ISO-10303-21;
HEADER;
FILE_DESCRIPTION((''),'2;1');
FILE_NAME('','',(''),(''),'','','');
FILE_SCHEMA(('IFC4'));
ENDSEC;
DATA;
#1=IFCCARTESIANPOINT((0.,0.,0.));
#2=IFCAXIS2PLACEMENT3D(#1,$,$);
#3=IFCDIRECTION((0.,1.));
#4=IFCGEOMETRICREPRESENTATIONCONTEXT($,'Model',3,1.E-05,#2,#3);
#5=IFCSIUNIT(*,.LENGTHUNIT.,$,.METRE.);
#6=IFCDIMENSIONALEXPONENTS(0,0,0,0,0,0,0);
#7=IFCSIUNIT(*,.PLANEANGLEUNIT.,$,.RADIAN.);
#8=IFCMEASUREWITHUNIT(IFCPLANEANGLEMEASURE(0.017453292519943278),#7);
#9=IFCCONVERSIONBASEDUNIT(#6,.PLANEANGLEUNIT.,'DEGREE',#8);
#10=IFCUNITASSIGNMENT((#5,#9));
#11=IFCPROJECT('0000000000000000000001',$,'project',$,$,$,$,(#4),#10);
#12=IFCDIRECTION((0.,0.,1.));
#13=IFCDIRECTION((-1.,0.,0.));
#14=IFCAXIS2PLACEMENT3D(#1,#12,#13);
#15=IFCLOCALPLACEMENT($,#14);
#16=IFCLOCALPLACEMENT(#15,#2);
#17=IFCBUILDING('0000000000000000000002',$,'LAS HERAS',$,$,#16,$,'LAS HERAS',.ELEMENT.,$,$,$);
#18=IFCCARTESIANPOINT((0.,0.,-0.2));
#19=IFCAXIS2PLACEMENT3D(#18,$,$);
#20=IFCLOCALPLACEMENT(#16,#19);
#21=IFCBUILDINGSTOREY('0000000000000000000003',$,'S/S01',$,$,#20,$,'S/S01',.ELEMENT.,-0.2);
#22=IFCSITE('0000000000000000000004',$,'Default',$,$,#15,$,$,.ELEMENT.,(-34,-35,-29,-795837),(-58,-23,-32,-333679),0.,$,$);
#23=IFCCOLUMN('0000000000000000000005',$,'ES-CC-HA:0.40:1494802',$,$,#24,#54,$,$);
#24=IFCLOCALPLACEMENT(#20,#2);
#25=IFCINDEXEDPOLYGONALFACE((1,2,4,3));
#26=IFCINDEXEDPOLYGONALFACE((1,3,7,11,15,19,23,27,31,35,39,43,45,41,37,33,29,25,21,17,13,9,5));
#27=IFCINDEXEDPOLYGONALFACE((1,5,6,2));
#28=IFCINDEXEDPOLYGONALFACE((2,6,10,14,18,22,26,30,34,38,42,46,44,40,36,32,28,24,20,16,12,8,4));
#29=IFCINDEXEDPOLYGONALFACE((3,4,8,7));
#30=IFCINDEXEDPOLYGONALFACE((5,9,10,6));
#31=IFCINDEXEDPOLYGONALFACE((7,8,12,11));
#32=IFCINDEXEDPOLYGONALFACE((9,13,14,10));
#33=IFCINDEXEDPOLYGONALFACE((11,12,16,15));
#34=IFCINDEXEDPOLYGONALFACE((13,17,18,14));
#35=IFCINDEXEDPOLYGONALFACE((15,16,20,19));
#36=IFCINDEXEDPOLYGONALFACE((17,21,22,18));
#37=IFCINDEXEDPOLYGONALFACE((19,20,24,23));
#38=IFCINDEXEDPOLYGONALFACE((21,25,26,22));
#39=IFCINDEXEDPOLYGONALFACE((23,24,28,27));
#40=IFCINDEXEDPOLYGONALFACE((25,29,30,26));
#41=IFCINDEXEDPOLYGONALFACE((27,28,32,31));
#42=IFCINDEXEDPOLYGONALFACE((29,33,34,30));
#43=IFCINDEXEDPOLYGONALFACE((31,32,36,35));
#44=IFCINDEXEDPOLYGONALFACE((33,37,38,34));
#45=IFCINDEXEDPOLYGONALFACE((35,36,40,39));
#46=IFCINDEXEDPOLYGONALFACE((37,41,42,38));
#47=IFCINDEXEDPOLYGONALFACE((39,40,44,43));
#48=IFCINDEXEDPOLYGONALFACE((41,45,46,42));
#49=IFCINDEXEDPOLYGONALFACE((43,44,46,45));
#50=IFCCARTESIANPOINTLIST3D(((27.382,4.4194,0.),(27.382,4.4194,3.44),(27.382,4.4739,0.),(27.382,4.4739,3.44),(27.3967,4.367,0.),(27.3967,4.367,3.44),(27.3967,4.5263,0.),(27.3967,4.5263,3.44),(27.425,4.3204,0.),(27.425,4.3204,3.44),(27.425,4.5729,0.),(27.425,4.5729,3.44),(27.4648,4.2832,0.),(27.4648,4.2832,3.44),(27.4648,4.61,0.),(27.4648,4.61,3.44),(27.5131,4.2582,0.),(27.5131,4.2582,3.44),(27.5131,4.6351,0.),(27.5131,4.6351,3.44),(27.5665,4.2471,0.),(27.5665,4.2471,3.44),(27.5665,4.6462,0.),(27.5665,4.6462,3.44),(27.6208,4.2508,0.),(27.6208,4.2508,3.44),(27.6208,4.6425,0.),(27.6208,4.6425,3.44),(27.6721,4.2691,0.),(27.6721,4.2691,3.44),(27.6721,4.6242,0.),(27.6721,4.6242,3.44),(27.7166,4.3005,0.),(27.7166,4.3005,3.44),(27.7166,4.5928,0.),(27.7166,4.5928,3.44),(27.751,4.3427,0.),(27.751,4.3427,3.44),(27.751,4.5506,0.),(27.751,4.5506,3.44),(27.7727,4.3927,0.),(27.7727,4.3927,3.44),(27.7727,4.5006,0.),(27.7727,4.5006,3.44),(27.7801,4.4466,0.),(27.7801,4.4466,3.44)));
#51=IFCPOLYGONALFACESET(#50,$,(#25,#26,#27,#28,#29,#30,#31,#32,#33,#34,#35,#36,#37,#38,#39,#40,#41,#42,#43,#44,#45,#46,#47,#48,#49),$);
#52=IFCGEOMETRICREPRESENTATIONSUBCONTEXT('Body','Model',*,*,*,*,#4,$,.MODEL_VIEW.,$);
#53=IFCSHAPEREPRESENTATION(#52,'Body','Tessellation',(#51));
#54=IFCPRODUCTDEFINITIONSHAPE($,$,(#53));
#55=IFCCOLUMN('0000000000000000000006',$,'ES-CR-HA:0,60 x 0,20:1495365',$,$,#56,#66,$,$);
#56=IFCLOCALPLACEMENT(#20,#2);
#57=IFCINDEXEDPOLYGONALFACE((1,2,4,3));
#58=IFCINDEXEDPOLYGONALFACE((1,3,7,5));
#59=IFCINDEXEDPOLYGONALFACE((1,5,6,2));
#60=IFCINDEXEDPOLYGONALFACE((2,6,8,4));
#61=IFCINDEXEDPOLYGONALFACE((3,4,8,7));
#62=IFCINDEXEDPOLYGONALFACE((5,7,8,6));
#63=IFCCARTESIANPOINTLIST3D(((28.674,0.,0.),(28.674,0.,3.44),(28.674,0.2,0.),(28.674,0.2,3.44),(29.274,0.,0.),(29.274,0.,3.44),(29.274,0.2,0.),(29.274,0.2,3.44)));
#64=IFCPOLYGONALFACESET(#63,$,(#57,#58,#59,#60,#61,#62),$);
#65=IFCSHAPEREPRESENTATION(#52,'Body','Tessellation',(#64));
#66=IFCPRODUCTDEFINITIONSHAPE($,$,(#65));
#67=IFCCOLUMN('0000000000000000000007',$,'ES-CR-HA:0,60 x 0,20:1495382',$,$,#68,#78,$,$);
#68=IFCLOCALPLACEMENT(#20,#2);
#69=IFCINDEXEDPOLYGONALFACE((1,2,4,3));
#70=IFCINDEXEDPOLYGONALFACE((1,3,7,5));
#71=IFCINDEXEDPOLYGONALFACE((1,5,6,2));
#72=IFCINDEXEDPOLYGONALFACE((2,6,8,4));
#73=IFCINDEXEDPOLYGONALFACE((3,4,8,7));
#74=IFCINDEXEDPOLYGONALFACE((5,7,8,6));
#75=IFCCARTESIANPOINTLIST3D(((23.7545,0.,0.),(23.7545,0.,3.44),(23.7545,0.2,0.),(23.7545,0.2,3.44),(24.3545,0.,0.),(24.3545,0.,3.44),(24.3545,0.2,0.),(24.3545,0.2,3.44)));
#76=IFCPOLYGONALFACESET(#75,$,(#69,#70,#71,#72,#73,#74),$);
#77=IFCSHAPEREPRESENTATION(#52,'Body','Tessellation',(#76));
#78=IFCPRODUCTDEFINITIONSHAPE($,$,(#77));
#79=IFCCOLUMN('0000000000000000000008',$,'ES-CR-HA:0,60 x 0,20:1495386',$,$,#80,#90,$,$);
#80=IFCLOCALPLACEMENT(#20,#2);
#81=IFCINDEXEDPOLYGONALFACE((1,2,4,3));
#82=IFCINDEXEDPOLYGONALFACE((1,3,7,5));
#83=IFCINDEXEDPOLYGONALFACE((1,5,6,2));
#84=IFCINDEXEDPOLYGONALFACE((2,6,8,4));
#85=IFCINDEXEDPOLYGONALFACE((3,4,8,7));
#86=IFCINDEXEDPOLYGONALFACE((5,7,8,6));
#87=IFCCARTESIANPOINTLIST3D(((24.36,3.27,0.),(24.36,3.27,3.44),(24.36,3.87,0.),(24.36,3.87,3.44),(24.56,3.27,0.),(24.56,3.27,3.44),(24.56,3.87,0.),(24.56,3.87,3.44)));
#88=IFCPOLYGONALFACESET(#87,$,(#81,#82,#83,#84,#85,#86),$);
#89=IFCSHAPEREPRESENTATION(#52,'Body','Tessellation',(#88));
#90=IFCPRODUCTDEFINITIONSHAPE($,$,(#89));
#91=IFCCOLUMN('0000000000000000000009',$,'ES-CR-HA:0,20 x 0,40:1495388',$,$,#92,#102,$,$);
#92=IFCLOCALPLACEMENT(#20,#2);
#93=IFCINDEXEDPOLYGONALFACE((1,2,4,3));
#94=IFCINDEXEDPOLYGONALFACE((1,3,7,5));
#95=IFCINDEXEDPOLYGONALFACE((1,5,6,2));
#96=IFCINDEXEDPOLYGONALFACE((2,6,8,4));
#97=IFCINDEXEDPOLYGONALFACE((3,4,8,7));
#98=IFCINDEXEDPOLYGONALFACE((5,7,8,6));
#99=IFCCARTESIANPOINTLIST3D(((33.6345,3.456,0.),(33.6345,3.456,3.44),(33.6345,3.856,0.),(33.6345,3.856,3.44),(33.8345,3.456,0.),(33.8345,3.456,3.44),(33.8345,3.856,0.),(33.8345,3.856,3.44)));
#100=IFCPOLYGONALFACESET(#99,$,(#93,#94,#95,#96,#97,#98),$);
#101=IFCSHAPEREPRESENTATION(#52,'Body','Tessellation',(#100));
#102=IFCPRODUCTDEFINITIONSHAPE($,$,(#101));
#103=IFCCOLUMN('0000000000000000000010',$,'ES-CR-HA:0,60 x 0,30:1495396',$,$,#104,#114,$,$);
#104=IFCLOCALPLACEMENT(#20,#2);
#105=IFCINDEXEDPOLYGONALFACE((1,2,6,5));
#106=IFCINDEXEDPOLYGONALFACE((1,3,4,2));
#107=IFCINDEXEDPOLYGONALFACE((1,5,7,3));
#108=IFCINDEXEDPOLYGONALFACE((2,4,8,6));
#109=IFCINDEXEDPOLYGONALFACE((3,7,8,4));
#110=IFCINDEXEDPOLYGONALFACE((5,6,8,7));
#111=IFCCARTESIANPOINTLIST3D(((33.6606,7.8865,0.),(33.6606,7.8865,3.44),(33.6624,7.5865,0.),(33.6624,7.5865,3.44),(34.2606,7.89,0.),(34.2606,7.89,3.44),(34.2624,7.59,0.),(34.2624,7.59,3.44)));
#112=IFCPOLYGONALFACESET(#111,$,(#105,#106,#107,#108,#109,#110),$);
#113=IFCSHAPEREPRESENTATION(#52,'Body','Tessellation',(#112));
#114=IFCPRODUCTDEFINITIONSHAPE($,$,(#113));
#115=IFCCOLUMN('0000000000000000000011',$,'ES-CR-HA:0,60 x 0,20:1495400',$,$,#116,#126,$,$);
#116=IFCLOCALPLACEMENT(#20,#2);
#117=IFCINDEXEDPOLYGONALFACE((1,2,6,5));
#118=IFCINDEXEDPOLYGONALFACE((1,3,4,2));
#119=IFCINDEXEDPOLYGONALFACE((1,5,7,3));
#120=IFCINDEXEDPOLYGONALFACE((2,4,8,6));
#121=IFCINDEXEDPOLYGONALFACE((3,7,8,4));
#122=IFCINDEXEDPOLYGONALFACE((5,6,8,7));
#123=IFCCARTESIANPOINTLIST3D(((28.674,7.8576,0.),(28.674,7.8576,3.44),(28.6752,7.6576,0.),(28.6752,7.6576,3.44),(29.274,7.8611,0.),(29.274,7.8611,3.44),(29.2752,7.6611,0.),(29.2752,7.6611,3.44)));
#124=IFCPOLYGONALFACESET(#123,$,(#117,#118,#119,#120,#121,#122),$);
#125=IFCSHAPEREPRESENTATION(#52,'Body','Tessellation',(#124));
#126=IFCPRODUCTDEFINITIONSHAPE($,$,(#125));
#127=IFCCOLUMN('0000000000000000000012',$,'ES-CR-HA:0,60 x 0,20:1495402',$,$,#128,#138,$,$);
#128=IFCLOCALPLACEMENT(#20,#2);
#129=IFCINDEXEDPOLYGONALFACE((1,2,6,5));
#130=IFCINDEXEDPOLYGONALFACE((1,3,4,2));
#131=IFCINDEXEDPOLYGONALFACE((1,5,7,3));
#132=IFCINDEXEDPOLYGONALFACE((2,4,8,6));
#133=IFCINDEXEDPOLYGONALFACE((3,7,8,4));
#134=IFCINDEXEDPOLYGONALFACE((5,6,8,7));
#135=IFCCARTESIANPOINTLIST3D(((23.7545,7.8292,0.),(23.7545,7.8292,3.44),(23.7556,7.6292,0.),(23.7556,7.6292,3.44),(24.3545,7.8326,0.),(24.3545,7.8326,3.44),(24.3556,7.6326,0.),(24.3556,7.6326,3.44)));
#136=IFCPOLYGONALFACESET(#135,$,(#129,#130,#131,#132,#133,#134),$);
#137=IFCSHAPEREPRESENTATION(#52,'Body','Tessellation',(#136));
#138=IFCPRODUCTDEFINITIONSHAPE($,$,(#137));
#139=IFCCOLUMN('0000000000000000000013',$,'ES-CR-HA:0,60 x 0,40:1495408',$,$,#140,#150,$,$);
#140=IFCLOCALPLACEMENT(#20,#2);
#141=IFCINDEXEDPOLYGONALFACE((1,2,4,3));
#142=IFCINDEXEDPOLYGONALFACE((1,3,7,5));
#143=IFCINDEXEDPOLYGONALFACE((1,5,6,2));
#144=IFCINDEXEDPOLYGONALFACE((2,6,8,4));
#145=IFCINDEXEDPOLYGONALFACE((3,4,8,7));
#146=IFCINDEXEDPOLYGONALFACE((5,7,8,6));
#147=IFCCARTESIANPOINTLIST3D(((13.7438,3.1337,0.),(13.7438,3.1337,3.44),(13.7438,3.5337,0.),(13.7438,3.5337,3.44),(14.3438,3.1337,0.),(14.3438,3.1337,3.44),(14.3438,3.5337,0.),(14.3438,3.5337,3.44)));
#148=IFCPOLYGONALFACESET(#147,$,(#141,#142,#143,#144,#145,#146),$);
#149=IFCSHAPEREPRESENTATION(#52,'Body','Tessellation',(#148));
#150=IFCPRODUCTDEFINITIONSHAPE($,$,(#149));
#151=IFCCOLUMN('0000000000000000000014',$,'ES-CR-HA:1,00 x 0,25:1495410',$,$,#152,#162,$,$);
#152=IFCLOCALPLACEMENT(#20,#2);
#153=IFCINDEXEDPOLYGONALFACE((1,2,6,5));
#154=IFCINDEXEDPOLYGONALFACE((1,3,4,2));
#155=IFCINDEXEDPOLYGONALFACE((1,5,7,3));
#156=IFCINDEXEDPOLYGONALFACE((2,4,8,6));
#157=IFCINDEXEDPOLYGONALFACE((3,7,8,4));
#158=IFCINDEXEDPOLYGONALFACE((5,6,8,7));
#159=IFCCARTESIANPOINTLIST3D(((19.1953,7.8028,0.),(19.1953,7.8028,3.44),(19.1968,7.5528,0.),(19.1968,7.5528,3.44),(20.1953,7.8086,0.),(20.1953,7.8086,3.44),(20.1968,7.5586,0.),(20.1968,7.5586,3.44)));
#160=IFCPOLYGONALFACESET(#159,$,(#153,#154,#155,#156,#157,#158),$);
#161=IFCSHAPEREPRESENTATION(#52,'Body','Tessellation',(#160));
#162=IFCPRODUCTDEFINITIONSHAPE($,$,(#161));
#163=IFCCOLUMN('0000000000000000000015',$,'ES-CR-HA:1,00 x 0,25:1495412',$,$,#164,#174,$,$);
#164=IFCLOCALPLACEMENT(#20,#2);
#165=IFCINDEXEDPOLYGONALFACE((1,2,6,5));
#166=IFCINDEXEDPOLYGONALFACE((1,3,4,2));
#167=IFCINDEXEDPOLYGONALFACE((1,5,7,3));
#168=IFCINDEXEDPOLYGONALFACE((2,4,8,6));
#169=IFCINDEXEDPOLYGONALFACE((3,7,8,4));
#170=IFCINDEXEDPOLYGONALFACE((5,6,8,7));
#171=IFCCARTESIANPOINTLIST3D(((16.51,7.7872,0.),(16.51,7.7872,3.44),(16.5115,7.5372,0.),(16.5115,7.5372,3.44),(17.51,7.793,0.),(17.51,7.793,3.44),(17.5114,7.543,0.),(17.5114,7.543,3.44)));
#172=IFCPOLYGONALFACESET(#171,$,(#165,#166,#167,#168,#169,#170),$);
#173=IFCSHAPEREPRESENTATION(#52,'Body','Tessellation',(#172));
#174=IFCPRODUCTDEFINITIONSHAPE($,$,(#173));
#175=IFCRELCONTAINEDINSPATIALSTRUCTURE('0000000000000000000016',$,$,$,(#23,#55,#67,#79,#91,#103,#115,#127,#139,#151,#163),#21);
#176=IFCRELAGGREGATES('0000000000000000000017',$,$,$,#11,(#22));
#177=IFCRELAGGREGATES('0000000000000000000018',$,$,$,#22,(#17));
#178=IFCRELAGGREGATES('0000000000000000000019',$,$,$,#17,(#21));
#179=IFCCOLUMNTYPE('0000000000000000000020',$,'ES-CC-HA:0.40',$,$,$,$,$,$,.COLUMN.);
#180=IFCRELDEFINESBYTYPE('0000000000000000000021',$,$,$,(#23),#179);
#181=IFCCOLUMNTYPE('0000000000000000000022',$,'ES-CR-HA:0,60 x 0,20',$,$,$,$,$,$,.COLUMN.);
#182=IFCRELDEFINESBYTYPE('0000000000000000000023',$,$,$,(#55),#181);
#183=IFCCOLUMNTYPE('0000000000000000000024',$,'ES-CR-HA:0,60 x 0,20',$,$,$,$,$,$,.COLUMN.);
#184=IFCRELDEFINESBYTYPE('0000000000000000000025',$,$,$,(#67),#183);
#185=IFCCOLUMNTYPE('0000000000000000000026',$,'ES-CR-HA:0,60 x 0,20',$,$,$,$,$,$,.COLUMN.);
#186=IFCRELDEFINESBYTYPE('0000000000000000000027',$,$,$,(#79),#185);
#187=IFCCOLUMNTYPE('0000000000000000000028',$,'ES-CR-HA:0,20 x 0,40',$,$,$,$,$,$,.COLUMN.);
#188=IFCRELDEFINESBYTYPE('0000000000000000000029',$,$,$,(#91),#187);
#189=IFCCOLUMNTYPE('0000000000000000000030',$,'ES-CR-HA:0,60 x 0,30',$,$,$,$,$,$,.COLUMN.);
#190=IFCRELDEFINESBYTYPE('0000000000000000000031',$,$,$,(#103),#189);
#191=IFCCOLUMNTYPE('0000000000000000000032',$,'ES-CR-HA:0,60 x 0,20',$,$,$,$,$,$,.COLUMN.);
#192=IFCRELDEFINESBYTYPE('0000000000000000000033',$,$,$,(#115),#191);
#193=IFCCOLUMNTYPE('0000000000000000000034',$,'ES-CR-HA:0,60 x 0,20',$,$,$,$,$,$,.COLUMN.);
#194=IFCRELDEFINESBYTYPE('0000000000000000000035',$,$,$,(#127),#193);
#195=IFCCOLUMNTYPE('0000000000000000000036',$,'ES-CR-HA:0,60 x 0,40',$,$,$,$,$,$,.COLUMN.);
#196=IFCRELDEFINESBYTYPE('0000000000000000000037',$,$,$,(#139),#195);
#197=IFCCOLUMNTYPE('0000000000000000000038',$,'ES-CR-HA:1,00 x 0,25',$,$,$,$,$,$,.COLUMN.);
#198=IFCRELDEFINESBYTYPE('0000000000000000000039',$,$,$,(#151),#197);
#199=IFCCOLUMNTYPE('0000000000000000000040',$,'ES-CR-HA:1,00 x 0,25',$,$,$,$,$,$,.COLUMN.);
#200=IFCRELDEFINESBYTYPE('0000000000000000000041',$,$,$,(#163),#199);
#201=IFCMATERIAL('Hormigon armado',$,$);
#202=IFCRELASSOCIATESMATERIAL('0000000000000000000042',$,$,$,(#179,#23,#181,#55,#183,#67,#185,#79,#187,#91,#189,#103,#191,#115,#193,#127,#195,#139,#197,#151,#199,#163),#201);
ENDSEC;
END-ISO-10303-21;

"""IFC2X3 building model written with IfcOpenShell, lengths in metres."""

from ifc_helpers import new_model, entity, si_unit, converted_unit, direction, frame, frame_2d, origin, origin_2d_with_axis, place, context, subcontext, project, spatial, rectangle, circle, extrude, source, transform, mapped, material, type_object, type_shapes, element, save


model = new_model("IFC2X3")

# Units and contexts
model_context = context("Model", 3, precision=1e-05, world=origin(), true_north=direction((0.0, 1.0)))
body_context = subcontext(model_context, "Body", "Model", "MODEL_VIEW")
ifc_project = project(units=[si_unit("LENGTHUNIT", "METRE"), converted_unit("PLANEANGLEUNIT", "DEGREE", entity("IfcPlaneAngleMeasure", 0.017453292519943278), si_unit("PLANEANGLEUNIT", "RADIAN"), dimensions=[0, 0, 0, 0, 0, 0, 0])], contexts=[model_context])

# Site, building, storey
site_placement = place(None, frame((0.0, 0.0, 0.0), z_axis=(0.0, 0.0, 1.0), x_axis=(-1.0, 0.0, 0.0)))
site = spatial("IfcSite", under=ifc_project, at=site_placement, Name="Default", CompositionType="ELEMENT", RefLatitude=(-34, -35, -29, -795837), RefLongitude=(-58, -23, -32, -333679), RefElevation=0.0)
building_placement = place(site_placement, origin())
building = spatial("IfcBuilding", under=site, at=building_placement, Name="LAS HERAS", LongName="LAS HERAS", CompositionType="ELEMENT")
storey_placement = place(building_placement, frame((0.0, 0.0, -0.2)))
storey = spatial("IfcBuildingStorey", under=building, at=storey_placement, Name="S/S01", LongName="S/S01", CompositionType="ELEMENT", Elevation=-0.2)

# Columns
ifc_material = material(Name="Hormigon armado")
column_type_1 = type_object("IfcColumnType", Name="ES-CC-HA:0.40", PredefinedType="COLUMN", material=ifc_material)
shared_shape_1 = source(origin(), body_context, "Body", "SweptSolid", [
    extrude(circle(Radius=0.2, at=origin_2d_with_axis()), frame((27.5801, 4.4466, -0.2)), (0.0, 0.0, 1.0), 3.44),
])
type_shapes(column_type_1, [shared_shape_1])
column_1_placement = place(storey_placement, frame((0.0, 0.0, 0.2)))
element("IfcColumn", 1, at=column_1_placement, inside=storey, type_object=column_type_1, material=ifc_material, Name="ES-CC-HA:0.40:1494802", context=body_context, shape_type="MappedRepresentation", body=[
    mapped(shared_shape_1, transform((0.0, 0.0, 0.0), scale=1.0)),
])
column_type_2 = type_object("IfcColumnType", Name="ES-CR-HA:0,60 x 0,20", PredefinedType="COLUMN", material=ifc_material)
shared_shape_2 = source(origin(), body_context, "Body", "SweptSolid", [
    extrude(rectangle(XDim=0.6, YDim=0.2, at=frame_2d((0.0, 0.0), x_axis=(1.0, 0.0))), frame((28.974, 0.1, -0.2), z_axis=(0.0, 0.0, 1.0), x_axis=(-1.0, 0.0, 0.0)), (0.0, 0.0, 1.0), 3.44),
])
type_shapes(column_type_2, [shared_shape_2])
column_2_placement = place(storey_placement, frame((0.0, 0.0, 0.2)))
element("IfcColumn", 2, at=column_2_placement, inside=storey, type_object=column_type_2, material=ifc_material, Name="ES-CR-HA:0,60 x 0,20:1495365", context=body_context, shape_type="MappedRepresentation", body=[
    mapped(shared_shape_2, transform((0.0, 0.0, 0.0), scale=1.0)),
])
column_type_3 = type_object("IfcColumnType", Name="ES-CR-HA:0,60 x 0,20", PredefinedType="COLUMN", material=ifc_material)
shared_shape_3 = source(origin(), body_context, "Body", "SweptSolid", [
    extrude(rectangle(XDim=0.6, YDim=0.2, at=frame_2d((0.0, 0.0), x_axis=(1.0, 0.0))), frame((24.0545, 0.1, -0.2), z_axis=(0.0, 0.0, 1.0), x_axis=(-1.0, 0.0, 0.0)), (0.0, 0.0, 1.0), 3.44),
])
type_shapes(column_type_3, [shared_shape_3])
column_3_placement = place(storey_placement, frame((0.0, 0.0, 0.2)))
element("IfcColumn", 3, at=column_3_placement, inside=storey, type_object=column_type_3, material=ifc_material, Name="ES-CR-HA:0,60 x 0,20:1495382", context=body_context, shape_type="MappedRepresentation", body=[
    mapped(shared_shape_3, transform((0.0, 0.0, 0.0), scale=1.0)),
])
column_type_4 = type_object("IfcColumnType", Name="ES-CR-HA:0,60 x 0,20", PredefinedType="COLUMN", material=ifc_material)
shared_shape_4 = source(origin(), body_context, "Body", "SweptSolid", [
    extrude(rectangle(XDim=0.6, YDim=0.2, at=frame_2d((0.0, 0.0), x_axis=(1.0, 0.0))), frame((24.46, 3.57, -0.2), z_axis=(0.0, 0.0, 1.0), x_axis=(0.0, -1.0, 0.0)), (0.0, 0.0, 1.0), 3.44),
])
type_shapes(column_type_4, [shared_shape_4])
column_4_placement = place(storey_placement, frame((0.0, 0.0, 0.2)))
element("IfcColumn", 4, at=column_4_placement, inside=storey, type_object=column_type_4, material=ifc_material, Name="ES-CR-HA:0,60 x 0,20:1495386", context=body_context, shape_type="MappedRepresentation", body=[
    mapped(shared_shape_4, transform((0.0, 0.0, 0.0), scale=1.0)),
])
column_type_5 = type_object("IfcColumnType", Name="ES-CR-HA:0,20 x 0,40", PredefinedType="COLUMN", material=ifc_material)
shared_shape_5 = source(origin(), body_context, "Body", "SweptSolid", [
    extrude(rectangle(XDim=0.2, YDim=0.4, at=frame_2d((0.0, 0.0662), x_axis=(1.0, 0.0))), frame((33.7345, 3.7222, -0.2), z_axis=(0.0, 0.0, 1.0), x_axis=(-1.0, 0.0, 0.0)), (0.0, 0.0, 1.0), 3.44),
])
type_shapes(column_type_5, [shared_shape_5])
column_5_placement = place(storey_placement, frame((0.0, 0.0, 0.2)))
element("IfcColumn", 5, at=column_5_placement, inside=storey, type_object=column_type_5, material=ifc_material, Name="ES-CR-HA:0,20 x 0,40:1495388", context=body_context, shape_type="MappedRepresentation", body=[
    mapped(shared_shape_5, transform((0.0, 0.0, 0.0), scale=1.0)),
])
column_type_6 = type_object("IfcColumnType", Name="ES-CR-HA:0,60 x 0,30", PredefinedType="COLUMN", material=ifc_material)
shared_shape_6 = source(origin(), body_context, "Body", "SweptSolid", [
    extrude(rectangle(XDim=0.6, YDim=0.3, at=frame_2d((0.0, 0.0), x_axis=(1.0, 0.0))), frame((33.9615, 7.7382, -0.2), z_axis=(0.0, 0.0, 1.0), x_axis=(-0.999983, -0.005788, 0.0)), (0.0, 0.0, 1.0), 3.44),
])
type_shapes(column_type_6, [shared_shape_6])
column_6_placement = place(storey_placement, frame((0.0, 0.0, 0.2)))
element("IfcColumn", 6, at=column_6_placement, inside=storey, type_object=column_type_6, material=ifc_material, Name="ES-CR-HA:0,60 x 0,30:1495396", context=body_context, shape_type="MappedRepresentation", body=[
    mapped(shared_shape_6, transform((0.0, 0.0, 0.0), scale=1.0)),
])
column_type_7 = type_object("IfcColumnType", Name="ES-CR-HA:0,60 x 0,20", PredefinedType="COLUMN", material=ifc_material)
shared_shape_7 = source(origin(), body_context, "Body", "SweptSolid", [
    extrude(rectangle(XDim=0.6, YDim=0.2, at=frame_2d((0.0, 0.0), x_axis=(1.0, 0.0))), frame((28.9746, 7.7594, -0.2), z_axis=(0.0, 0.0, 1.0), x_axis=(-0.999983, -0.005788, 0.0)), (0.0, 0.0, 1.0), 3.44),
])
type_shapes(column_type_7, [shared_shape_7])
column_7_placement = place(storey_placement, frame((0.0, 0.0, 0.2)))
element("IfcColumn", 7, at=column_7_placement, inside=storey, type_object=column_type_7, material=ifc_material, Name="ES-CR-HA:0,60 x 0,20:1495400", context=body_context, shape_type="MappedRepresentation", body=[
    mapped(shared_shape_7, transform((0.0, 0.0, 0.0), scale=1.0)),
])
column_type_8 = type_object("IfcColumnType", Name="ES-CR-HA:0,60 x 0,20", PredefinedType="COLUMN", material=ifc_material)
shared_shape_8 = source(origin(), body_context, "Body", "SweptSolid", [
    extrude(rectangle(XDim=0.6, YDim=0.2, at=frame_2d((0.0, 0.0), x_axis=(1.0, 0.0))), frame((24.0551, 7.7309, -0.2), z_axis=(0.0, 0.0, 1.0), x_axis=(-0.999983, -0.005788, 0.0)), (0.0, 0.0, 1.0), 3.44),
])
type_shapes(column_type_8, [shared_shape_8])
column_8_placement = place(storey_placement, frame((0.0, 0.0, 0.2)))
element("IfcColumn", 8, at=column_8_placement, inside=storey, type_object=column_type_8, material=ifc_material, Name="ES-CR-HA:0,60 x 0,20:1495402", context=body_context, shape_type="MappedRepresentation", body=[
    mapped(shared_shape_8, transform((0.0, 0.0, 0.0), scale=1.0)),
])
column_type_9 = type_object("IfcColumnType", Name="ES-CR-HA:0,60 x 0,40", PredefinedType="COLUMN", material=ifc_material)
shared_shape_9 = source(origin(), body_context, "Body", "SweptSolid", [
    extrude(rectangle(XDim=0.6, YDim=0.4, at=frame_2d((0.0, 0.0), x_axis=(1.0, 0.0))), frame((14.0438, 3.3337, -0.2), z_axis=(0.0, 0.0, 1.0), x_axis=(-1.0, 0.0, 0.0)), (0.0, 0.0, 1.0), 3.44),
])
type_shapes(column_type_9, [shared_shape_9])
column_9_placement = place(storey_placement, frame((0.0, 0.0, 0.2)))
element("IfcColumn", 9, at=column_9_placement, inside=storey, type_object=column_type_9, material=ifc_material, Name="ES-CR-HA:0,60 x 0,40:1495408", context=body_context, shape_type="MappedRepresentation", body=[
    mapped(shared_shape_9, transform((0.0, 0.0, 0.0), scale=1.0)),
])
column_type_10 = type_object("IfcColumnType", Name="ES-CR-HA:1,00 x 0,25", PredefinedType="COLUMN", material=ifc_material)
shared_shape_10 = source(origin(), body_context, "Body", "SweptSolid", [
    extrude(rectangle(XDim=1.0, YDim=0.25, at=frame_2d((0.0, 0.0), x_axis=(1.0, 0.0))), frame((19.6961, 7.6807, -0.2), z_axis=(0.0, 0.0, 1.0), x_axis=(-0.999983, -0.005788, 0.0)), (0.0, 0.0, 1.0), 3.44),
])
type_shapes(column_type_10, [shared_shape_10])
column_10_placement = place(storey_placement, frame((0.0, 0.0, 0.2)))
element("IfcColumn", 10, at=column_10_placement, inside=storey, type_object=column_type_10, material=ifc_material, Name="ES-CR-HA:1,00 x 0,25:1495410", context=body_context, shape_type="MappedRepresentation", body=[
    mapped(shared_shape_10, transform((0.0, 0.0, 0.0), scale=1.0)),
])
column_type_11 = type_object("IfcColumnType", Name="ES-CR-HA:1,00 x 0,25", PredefinedType="COLUMN", material=ifc_material)
shared_shape_11 = source(origin(), body_context, "Body", "SweptSolid", [
    extrude(rectangle(XDim=1.0, YDim=0.25, at=frame_2d((0.0, 0.0), x_axis=(1.0, 0.0))), frame((17.0107, 7.6651, -0.2), z_axis=(0.0, 0.0, 1.0), x_axis=(-0.999983, -0.005788, 0.0)), (0.0, 0.0, 1.0), 3.44),
])
type_shapes(column_type_11, [shared_shape_11])
column_11_placement = place(storey_placement, frame((0.0, 0.0, 0.2)))
element("IfcColumn", 11, at=column_11_placement, inside=storey, type_object=column_type_11, material=ifc_material, Name="ES-CR-HA:1,00 x 0,25:1495412", context=body_context, shape_type="MappedRepresentation", body=[
    mapped(shared_shape_11, transform((0.0, 0.0, 0.0), scale=1.0)),
])

save(model, "model.ifc")
